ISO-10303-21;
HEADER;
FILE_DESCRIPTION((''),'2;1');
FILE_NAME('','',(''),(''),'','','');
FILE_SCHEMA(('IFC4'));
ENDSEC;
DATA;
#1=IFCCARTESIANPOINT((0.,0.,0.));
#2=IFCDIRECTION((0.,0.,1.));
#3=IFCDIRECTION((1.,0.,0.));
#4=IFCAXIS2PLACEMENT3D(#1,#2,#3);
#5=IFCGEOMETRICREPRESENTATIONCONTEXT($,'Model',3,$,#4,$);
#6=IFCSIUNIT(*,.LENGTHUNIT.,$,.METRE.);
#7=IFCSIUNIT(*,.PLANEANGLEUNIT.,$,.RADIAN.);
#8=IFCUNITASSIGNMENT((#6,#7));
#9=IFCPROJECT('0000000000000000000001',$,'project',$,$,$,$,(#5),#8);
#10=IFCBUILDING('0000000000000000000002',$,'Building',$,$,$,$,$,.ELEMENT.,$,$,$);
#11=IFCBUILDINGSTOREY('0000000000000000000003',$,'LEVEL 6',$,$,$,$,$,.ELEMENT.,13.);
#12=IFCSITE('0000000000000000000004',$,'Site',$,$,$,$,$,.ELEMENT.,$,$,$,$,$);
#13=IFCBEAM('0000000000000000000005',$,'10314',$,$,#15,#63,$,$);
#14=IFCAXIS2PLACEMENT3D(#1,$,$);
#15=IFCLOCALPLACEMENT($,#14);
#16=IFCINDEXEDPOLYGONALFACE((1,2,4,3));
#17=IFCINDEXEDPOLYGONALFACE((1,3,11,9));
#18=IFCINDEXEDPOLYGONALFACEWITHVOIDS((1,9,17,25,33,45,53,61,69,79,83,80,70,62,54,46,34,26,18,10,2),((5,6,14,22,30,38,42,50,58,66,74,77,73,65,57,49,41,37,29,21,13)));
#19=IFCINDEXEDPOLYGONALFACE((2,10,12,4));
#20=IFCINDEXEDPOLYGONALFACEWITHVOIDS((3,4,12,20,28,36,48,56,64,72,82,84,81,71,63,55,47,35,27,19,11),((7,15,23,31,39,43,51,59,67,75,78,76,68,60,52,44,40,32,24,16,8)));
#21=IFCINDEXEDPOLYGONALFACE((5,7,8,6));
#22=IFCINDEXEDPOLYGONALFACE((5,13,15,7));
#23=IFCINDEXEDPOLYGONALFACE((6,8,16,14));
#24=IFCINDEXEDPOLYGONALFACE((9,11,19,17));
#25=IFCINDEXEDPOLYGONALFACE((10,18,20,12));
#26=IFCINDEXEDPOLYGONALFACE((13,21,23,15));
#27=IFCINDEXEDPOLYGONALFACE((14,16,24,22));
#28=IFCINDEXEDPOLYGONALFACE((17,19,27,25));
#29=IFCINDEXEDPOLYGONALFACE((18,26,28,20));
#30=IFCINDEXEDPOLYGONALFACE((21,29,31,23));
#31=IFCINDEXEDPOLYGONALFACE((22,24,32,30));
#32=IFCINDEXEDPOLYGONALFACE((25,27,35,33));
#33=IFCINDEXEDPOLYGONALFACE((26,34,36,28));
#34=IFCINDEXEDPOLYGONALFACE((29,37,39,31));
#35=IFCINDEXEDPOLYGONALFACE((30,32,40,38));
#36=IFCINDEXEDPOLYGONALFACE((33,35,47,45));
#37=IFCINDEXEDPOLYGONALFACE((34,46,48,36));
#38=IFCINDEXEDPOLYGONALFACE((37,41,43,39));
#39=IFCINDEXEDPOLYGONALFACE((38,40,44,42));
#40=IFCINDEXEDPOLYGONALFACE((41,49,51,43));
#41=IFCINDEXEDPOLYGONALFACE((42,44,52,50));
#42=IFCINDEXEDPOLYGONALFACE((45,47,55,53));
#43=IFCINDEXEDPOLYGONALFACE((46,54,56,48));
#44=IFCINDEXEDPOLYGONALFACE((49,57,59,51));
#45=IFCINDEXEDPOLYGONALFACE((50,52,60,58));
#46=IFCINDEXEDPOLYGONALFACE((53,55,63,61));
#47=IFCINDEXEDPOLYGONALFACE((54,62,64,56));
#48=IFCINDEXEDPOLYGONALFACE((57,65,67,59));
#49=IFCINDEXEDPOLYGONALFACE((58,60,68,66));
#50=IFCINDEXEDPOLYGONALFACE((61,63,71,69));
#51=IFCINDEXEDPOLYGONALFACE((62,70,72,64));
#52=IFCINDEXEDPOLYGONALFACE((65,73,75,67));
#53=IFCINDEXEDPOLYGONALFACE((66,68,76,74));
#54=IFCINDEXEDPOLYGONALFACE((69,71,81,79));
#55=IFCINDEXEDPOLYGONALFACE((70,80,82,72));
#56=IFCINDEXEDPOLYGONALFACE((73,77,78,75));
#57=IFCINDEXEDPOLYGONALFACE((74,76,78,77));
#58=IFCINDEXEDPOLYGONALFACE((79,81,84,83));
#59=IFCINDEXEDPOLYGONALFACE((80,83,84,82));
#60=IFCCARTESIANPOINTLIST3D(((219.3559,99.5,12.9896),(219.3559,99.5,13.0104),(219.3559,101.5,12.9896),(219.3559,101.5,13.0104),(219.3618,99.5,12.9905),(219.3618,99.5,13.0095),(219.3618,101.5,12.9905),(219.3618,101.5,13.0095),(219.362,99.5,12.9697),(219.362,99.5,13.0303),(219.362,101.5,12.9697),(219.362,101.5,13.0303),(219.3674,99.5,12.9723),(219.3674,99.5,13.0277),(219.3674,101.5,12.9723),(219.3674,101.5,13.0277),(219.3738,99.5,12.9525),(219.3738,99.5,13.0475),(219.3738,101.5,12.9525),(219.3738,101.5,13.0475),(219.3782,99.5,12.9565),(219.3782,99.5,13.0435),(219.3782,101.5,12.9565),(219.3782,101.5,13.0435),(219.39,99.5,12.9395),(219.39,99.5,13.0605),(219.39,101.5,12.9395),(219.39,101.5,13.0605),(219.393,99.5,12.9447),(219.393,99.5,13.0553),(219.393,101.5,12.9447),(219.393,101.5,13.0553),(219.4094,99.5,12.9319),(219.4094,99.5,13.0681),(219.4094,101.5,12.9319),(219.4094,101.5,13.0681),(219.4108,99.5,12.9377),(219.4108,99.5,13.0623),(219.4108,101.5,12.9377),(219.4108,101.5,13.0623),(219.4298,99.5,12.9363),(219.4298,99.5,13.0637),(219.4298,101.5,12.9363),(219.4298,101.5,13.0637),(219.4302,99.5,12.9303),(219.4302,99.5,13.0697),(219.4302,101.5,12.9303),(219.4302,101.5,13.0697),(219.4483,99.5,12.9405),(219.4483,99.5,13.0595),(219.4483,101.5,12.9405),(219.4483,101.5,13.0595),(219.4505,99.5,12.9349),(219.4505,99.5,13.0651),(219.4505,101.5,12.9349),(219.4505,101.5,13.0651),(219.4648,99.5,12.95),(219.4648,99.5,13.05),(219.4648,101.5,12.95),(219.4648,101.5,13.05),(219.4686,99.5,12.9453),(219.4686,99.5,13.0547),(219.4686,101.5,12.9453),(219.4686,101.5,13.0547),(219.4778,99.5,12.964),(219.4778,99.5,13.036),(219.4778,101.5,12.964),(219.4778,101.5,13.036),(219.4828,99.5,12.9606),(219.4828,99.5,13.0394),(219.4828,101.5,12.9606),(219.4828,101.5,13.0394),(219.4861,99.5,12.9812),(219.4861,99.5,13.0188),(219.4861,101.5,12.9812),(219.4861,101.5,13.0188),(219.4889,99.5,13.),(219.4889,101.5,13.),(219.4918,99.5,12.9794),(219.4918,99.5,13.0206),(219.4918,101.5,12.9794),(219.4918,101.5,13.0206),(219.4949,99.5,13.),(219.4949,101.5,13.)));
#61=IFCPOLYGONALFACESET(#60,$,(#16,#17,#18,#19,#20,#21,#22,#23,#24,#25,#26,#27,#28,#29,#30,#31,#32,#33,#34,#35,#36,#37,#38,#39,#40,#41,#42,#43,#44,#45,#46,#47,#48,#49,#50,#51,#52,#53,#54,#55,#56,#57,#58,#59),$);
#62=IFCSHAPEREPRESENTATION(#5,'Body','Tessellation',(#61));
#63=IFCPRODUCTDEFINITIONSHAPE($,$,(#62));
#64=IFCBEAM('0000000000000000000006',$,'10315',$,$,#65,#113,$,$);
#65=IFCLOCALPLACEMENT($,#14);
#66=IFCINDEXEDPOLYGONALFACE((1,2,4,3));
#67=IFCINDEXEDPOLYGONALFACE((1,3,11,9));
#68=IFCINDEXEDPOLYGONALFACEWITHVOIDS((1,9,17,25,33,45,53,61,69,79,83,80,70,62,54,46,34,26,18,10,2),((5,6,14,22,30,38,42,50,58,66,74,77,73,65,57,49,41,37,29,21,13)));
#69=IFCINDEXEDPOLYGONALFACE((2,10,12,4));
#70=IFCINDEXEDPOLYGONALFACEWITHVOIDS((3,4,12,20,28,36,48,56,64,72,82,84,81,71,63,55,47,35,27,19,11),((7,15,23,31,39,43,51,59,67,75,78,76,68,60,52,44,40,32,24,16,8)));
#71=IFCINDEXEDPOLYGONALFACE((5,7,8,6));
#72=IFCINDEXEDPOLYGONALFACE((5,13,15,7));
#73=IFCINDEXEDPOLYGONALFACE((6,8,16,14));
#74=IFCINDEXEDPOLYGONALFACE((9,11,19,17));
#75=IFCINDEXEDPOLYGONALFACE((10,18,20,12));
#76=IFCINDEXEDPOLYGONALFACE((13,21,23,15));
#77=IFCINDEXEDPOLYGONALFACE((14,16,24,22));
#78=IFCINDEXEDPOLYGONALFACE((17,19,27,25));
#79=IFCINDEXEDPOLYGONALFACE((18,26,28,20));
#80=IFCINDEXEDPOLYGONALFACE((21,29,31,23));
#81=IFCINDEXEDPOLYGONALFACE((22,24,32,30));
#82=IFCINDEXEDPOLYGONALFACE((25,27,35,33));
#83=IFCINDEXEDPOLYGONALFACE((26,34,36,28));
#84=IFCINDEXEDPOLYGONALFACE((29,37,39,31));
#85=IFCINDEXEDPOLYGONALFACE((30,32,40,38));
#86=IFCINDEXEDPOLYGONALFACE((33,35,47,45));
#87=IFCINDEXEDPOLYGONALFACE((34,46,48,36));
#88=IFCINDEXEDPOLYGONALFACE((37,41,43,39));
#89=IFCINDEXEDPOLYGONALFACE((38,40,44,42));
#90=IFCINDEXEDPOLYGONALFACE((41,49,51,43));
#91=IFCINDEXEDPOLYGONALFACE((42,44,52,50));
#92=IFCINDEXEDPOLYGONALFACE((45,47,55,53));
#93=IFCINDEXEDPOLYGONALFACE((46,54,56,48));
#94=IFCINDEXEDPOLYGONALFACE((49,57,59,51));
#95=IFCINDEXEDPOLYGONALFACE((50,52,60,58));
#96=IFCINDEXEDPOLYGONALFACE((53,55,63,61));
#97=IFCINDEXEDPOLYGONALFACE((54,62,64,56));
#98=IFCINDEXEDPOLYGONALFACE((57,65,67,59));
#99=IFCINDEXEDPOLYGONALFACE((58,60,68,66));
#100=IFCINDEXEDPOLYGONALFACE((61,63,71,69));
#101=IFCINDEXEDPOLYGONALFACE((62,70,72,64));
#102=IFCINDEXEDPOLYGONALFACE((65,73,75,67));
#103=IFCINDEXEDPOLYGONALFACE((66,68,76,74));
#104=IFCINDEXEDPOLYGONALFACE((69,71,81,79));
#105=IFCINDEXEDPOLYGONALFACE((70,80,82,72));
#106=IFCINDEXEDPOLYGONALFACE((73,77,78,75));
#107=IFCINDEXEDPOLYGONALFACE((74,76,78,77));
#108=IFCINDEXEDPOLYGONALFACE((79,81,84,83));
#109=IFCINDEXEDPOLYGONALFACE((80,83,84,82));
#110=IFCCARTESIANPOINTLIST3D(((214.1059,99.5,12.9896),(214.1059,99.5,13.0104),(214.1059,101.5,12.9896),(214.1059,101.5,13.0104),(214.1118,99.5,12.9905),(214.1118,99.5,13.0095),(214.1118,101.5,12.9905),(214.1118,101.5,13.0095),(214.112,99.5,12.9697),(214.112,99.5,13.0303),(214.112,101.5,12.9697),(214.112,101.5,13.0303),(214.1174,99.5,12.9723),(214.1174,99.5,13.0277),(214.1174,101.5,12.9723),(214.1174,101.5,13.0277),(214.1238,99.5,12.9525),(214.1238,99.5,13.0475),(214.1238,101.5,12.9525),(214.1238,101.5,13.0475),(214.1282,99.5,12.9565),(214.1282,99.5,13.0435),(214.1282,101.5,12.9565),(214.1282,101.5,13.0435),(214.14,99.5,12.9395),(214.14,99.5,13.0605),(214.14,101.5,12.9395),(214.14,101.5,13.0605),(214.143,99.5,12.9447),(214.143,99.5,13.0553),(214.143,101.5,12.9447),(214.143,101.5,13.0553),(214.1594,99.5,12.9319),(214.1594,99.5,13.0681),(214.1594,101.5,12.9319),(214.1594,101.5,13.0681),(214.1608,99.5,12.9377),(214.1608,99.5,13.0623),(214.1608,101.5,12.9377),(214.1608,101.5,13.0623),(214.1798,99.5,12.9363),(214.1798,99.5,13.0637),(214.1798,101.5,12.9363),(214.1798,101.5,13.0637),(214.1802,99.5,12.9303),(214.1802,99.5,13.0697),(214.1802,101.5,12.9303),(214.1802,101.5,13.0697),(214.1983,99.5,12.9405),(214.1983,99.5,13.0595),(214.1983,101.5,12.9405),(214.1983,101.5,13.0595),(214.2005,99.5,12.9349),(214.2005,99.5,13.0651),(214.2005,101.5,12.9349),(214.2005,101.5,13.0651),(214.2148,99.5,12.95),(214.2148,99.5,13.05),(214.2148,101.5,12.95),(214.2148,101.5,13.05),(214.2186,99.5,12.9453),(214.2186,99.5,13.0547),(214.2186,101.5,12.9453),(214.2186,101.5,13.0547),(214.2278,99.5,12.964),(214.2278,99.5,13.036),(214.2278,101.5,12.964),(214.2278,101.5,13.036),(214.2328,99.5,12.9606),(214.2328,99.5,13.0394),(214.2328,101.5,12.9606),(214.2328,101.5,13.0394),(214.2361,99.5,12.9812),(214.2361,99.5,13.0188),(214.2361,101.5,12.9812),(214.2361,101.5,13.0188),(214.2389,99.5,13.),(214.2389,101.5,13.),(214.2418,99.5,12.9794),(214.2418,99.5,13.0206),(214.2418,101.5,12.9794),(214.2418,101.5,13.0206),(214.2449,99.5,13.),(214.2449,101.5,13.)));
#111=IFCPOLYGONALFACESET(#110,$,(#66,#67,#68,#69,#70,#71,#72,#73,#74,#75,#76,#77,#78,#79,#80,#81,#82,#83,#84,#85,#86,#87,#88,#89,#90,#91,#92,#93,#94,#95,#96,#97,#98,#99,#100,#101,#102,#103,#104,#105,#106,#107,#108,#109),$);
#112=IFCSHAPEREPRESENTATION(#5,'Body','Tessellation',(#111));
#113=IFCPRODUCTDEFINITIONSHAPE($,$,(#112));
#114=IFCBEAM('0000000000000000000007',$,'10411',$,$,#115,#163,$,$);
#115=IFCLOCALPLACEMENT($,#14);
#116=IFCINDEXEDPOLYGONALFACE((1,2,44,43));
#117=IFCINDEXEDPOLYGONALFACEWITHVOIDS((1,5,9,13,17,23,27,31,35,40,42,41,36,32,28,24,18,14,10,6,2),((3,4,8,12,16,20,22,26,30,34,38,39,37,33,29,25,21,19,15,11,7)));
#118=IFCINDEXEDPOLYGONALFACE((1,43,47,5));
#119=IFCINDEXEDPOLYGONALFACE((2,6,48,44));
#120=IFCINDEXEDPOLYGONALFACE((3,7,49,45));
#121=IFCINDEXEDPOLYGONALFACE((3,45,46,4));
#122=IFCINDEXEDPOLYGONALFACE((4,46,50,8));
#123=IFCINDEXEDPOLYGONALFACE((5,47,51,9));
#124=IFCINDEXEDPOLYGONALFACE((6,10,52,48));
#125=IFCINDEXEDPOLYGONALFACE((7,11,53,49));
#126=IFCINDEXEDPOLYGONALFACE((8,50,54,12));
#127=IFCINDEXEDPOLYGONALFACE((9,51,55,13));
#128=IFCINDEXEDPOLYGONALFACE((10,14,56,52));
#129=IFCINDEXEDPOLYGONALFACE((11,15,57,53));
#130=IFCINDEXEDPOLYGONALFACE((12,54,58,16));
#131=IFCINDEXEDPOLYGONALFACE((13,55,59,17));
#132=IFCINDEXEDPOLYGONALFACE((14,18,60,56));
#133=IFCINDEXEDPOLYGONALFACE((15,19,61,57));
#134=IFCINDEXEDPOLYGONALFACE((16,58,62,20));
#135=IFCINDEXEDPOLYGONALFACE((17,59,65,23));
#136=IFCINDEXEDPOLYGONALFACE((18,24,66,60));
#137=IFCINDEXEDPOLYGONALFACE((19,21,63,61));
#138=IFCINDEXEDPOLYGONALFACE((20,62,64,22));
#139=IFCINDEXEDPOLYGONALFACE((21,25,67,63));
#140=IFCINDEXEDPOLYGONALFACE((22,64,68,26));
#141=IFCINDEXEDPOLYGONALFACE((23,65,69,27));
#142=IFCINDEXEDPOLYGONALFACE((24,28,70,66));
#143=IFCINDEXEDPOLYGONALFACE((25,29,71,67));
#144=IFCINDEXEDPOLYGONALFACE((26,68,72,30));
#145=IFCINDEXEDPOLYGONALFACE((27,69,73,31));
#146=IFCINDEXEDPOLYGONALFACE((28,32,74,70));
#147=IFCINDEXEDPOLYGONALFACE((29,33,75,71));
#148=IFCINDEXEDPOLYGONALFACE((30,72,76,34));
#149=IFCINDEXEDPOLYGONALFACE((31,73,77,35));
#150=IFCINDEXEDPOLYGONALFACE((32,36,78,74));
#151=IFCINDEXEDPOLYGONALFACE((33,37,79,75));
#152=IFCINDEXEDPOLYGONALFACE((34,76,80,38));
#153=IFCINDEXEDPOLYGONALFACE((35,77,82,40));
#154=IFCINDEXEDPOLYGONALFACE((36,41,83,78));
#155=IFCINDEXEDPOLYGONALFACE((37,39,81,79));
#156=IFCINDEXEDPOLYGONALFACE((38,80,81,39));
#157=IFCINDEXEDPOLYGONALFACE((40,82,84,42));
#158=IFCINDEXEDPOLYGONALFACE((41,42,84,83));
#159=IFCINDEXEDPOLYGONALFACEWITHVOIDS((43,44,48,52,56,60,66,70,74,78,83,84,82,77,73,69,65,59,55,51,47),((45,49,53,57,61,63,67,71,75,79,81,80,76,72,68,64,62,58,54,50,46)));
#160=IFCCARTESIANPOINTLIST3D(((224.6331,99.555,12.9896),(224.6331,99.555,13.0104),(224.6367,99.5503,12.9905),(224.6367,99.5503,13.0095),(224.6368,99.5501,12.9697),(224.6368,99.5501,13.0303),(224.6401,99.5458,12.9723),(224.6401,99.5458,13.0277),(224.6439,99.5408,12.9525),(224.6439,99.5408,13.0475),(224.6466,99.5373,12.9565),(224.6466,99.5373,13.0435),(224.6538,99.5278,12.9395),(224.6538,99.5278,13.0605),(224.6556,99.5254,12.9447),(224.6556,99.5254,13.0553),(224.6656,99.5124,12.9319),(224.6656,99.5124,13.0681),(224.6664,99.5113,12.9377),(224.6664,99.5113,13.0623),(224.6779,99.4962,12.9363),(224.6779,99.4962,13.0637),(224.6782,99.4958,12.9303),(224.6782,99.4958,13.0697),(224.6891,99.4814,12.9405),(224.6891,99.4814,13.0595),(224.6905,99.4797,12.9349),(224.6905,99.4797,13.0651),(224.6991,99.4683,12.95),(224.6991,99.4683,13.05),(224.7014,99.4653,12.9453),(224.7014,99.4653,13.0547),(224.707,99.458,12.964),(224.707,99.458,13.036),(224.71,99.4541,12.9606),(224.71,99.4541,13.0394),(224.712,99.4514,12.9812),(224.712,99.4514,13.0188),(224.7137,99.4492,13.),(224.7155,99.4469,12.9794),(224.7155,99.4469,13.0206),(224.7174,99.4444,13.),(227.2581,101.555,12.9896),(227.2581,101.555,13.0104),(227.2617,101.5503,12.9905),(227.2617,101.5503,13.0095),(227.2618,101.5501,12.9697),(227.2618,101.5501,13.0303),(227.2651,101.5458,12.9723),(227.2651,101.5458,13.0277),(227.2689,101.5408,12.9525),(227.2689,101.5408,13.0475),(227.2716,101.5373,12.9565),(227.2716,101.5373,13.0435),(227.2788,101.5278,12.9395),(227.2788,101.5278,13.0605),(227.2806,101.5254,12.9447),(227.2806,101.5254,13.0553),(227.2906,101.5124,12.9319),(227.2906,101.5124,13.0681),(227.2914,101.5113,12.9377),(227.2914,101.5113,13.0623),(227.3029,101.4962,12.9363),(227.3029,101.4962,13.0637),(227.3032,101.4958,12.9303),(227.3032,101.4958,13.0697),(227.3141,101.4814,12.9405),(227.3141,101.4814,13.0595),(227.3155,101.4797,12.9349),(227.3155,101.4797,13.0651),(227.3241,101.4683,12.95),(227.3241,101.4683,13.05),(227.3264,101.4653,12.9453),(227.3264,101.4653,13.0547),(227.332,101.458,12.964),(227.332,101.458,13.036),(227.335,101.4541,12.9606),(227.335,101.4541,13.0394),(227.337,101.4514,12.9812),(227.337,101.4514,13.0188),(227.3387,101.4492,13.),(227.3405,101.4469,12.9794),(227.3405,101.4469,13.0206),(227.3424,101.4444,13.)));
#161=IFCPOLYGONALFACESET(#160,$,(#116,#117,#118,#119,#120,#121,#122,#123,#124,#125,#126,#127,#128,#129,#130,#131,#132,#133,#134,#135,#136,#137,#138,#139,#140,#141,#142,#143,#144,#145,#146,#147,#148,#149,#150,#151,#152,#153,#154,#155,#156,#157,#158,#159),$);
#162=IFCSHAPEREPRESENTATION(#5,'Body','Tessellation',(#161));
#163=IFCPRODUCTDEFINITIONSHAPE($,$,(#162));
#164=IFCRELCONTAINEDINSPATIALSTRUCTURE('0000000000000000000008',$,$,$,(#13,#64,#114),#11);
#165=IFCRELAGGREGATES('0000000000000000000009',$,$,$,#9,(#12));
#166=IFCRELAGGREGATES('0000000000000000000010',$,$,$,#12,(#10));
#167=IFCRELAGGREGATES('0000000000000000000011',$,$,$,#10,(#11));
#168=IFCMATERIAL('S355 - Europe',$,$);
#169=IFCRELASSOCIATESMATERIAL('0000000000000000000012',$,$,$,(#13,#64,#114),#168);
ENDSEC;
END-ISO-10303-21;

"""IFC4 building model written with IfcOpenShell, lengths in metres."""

from ifc_helpers import new_model, si_unit, frame, origin_with_axes, origin_2d_with_axis, place, context, project, spatial, hollow_circle, extrude, material, material_profile, profile_set, profile_usage, element, save


model = new_model("IFC4")

# Units and contexts
model_context = context("Model", 3, world=origin_with_axes())
ifc_project = project(units=[si_unit("LENGTHUNIT", "METRE"), si_unit("PLANEANGLEUNIT", "RADIAN")], contexts=[model_context])

# Site, building, storey
site = spatial("IfcSite", under=ifc_project, Name="Site", CompositionType="ELEMENT")
building = spatial("IfcBuilding", under=site, Name="Building", CompositionType="ELEMENT")
storey = spatial("IfcBuildingStorey", under=building, Name="LEVEL 6", CompositionType="ELEMENT", Elevation=13.0)

# Shared definitions
ifc_material = material(Name="S355 - Europe")

# Beams
ifc_material_profile_1 = material_profile(ifc_material, hollow_circle(Radius=0.0699, WallThickness=0.006, at=origin_2d_with_axis()))
ifc_profile_set_1 = profile_set([ifc_material_profile_1])
ifc_profile_usage_1 = profile_usage(ifc_profile_set_1, cardinal=10)
beam_1_placement = place(None, frame((219.425, 101.5, 13.0), z_axis=(0.0, -1.0, 0.0), x_axis=(1.0, 0.0, 0.0)))
element("IfcBeam", 1, at=beam_1_placement, inside=storey, material=ifc_profile_usage_1, Name="10314", context=model_context, shape_type="SweptSolid", body=[
    extrude(hollow_circle(Radius=0.0699, WallThickness=0.006, at=origin_2d_with_axis()), origin_with_axes(), (0.0, 0.0, 1.0), 2.0),
])
ifc_material_profile_2 = material_profile(ifc_material, hollow_circle(Radius=0.0699, WallThickness=0.006, at=origin_2d_with_axis()))
ifc_profile_set_2 = profile_set([ifc_material_profile_2])
ifc_profile_usage_2 = profile_usage(ifc_profile_set_2, cardinal=10)
beam_2_placement = place(None, frame((214.175, 101.5, 13.0), z_axis=(0.0, -1.0, 0.0), x_axis=(1.0, 0.0, 0.0)))
element("IfcBeam", 2, at=beam_2_placement, inside=storey, material=ifc_profile_usage_2, Name="10315", context=model_context, shape_type="SweptSolid", body=[
    extrude(hollow_circle(Radius=0.0699, WallThickness=0.006, at=origin_2d_with_axis()), origin_with_axes(), (0.0, 0.0, 1.0), 2.0),
])
ifc_material_profile_3 = material_profile(ifc_material, hollow_circle(Radius=0.0699, WallThickness=0.006, at=origin_2d_with_axis()))
ifc_profile_set_3 = profile_set([ifc_material_profile_3])
ifc_profile_usage_3 = profile_usage(ifc_profile_set_3, cardinal=10)
beam_3_placement = place(None, frame((227.3, 101.5, 13.0), z_axis=(-0.795432, -0.606043, 0.0), x_axis=(0.606043, -0.795432, 0.0)))
element("IfcBeam", 3, at=beam_3_placement, inside=storey, material=ifc_profile_usage_3, Name="10411", context=model_context, shape_type="SweptSolid", body=[
    extrude(hollow_circle(Radius=0.0699, WallThickness=0.006, at=origin_2d_with_axis()), origin_with_axes(), (0.0, 0.0, 1.0), 3.3001),
])

save(model, "model.ifc")
